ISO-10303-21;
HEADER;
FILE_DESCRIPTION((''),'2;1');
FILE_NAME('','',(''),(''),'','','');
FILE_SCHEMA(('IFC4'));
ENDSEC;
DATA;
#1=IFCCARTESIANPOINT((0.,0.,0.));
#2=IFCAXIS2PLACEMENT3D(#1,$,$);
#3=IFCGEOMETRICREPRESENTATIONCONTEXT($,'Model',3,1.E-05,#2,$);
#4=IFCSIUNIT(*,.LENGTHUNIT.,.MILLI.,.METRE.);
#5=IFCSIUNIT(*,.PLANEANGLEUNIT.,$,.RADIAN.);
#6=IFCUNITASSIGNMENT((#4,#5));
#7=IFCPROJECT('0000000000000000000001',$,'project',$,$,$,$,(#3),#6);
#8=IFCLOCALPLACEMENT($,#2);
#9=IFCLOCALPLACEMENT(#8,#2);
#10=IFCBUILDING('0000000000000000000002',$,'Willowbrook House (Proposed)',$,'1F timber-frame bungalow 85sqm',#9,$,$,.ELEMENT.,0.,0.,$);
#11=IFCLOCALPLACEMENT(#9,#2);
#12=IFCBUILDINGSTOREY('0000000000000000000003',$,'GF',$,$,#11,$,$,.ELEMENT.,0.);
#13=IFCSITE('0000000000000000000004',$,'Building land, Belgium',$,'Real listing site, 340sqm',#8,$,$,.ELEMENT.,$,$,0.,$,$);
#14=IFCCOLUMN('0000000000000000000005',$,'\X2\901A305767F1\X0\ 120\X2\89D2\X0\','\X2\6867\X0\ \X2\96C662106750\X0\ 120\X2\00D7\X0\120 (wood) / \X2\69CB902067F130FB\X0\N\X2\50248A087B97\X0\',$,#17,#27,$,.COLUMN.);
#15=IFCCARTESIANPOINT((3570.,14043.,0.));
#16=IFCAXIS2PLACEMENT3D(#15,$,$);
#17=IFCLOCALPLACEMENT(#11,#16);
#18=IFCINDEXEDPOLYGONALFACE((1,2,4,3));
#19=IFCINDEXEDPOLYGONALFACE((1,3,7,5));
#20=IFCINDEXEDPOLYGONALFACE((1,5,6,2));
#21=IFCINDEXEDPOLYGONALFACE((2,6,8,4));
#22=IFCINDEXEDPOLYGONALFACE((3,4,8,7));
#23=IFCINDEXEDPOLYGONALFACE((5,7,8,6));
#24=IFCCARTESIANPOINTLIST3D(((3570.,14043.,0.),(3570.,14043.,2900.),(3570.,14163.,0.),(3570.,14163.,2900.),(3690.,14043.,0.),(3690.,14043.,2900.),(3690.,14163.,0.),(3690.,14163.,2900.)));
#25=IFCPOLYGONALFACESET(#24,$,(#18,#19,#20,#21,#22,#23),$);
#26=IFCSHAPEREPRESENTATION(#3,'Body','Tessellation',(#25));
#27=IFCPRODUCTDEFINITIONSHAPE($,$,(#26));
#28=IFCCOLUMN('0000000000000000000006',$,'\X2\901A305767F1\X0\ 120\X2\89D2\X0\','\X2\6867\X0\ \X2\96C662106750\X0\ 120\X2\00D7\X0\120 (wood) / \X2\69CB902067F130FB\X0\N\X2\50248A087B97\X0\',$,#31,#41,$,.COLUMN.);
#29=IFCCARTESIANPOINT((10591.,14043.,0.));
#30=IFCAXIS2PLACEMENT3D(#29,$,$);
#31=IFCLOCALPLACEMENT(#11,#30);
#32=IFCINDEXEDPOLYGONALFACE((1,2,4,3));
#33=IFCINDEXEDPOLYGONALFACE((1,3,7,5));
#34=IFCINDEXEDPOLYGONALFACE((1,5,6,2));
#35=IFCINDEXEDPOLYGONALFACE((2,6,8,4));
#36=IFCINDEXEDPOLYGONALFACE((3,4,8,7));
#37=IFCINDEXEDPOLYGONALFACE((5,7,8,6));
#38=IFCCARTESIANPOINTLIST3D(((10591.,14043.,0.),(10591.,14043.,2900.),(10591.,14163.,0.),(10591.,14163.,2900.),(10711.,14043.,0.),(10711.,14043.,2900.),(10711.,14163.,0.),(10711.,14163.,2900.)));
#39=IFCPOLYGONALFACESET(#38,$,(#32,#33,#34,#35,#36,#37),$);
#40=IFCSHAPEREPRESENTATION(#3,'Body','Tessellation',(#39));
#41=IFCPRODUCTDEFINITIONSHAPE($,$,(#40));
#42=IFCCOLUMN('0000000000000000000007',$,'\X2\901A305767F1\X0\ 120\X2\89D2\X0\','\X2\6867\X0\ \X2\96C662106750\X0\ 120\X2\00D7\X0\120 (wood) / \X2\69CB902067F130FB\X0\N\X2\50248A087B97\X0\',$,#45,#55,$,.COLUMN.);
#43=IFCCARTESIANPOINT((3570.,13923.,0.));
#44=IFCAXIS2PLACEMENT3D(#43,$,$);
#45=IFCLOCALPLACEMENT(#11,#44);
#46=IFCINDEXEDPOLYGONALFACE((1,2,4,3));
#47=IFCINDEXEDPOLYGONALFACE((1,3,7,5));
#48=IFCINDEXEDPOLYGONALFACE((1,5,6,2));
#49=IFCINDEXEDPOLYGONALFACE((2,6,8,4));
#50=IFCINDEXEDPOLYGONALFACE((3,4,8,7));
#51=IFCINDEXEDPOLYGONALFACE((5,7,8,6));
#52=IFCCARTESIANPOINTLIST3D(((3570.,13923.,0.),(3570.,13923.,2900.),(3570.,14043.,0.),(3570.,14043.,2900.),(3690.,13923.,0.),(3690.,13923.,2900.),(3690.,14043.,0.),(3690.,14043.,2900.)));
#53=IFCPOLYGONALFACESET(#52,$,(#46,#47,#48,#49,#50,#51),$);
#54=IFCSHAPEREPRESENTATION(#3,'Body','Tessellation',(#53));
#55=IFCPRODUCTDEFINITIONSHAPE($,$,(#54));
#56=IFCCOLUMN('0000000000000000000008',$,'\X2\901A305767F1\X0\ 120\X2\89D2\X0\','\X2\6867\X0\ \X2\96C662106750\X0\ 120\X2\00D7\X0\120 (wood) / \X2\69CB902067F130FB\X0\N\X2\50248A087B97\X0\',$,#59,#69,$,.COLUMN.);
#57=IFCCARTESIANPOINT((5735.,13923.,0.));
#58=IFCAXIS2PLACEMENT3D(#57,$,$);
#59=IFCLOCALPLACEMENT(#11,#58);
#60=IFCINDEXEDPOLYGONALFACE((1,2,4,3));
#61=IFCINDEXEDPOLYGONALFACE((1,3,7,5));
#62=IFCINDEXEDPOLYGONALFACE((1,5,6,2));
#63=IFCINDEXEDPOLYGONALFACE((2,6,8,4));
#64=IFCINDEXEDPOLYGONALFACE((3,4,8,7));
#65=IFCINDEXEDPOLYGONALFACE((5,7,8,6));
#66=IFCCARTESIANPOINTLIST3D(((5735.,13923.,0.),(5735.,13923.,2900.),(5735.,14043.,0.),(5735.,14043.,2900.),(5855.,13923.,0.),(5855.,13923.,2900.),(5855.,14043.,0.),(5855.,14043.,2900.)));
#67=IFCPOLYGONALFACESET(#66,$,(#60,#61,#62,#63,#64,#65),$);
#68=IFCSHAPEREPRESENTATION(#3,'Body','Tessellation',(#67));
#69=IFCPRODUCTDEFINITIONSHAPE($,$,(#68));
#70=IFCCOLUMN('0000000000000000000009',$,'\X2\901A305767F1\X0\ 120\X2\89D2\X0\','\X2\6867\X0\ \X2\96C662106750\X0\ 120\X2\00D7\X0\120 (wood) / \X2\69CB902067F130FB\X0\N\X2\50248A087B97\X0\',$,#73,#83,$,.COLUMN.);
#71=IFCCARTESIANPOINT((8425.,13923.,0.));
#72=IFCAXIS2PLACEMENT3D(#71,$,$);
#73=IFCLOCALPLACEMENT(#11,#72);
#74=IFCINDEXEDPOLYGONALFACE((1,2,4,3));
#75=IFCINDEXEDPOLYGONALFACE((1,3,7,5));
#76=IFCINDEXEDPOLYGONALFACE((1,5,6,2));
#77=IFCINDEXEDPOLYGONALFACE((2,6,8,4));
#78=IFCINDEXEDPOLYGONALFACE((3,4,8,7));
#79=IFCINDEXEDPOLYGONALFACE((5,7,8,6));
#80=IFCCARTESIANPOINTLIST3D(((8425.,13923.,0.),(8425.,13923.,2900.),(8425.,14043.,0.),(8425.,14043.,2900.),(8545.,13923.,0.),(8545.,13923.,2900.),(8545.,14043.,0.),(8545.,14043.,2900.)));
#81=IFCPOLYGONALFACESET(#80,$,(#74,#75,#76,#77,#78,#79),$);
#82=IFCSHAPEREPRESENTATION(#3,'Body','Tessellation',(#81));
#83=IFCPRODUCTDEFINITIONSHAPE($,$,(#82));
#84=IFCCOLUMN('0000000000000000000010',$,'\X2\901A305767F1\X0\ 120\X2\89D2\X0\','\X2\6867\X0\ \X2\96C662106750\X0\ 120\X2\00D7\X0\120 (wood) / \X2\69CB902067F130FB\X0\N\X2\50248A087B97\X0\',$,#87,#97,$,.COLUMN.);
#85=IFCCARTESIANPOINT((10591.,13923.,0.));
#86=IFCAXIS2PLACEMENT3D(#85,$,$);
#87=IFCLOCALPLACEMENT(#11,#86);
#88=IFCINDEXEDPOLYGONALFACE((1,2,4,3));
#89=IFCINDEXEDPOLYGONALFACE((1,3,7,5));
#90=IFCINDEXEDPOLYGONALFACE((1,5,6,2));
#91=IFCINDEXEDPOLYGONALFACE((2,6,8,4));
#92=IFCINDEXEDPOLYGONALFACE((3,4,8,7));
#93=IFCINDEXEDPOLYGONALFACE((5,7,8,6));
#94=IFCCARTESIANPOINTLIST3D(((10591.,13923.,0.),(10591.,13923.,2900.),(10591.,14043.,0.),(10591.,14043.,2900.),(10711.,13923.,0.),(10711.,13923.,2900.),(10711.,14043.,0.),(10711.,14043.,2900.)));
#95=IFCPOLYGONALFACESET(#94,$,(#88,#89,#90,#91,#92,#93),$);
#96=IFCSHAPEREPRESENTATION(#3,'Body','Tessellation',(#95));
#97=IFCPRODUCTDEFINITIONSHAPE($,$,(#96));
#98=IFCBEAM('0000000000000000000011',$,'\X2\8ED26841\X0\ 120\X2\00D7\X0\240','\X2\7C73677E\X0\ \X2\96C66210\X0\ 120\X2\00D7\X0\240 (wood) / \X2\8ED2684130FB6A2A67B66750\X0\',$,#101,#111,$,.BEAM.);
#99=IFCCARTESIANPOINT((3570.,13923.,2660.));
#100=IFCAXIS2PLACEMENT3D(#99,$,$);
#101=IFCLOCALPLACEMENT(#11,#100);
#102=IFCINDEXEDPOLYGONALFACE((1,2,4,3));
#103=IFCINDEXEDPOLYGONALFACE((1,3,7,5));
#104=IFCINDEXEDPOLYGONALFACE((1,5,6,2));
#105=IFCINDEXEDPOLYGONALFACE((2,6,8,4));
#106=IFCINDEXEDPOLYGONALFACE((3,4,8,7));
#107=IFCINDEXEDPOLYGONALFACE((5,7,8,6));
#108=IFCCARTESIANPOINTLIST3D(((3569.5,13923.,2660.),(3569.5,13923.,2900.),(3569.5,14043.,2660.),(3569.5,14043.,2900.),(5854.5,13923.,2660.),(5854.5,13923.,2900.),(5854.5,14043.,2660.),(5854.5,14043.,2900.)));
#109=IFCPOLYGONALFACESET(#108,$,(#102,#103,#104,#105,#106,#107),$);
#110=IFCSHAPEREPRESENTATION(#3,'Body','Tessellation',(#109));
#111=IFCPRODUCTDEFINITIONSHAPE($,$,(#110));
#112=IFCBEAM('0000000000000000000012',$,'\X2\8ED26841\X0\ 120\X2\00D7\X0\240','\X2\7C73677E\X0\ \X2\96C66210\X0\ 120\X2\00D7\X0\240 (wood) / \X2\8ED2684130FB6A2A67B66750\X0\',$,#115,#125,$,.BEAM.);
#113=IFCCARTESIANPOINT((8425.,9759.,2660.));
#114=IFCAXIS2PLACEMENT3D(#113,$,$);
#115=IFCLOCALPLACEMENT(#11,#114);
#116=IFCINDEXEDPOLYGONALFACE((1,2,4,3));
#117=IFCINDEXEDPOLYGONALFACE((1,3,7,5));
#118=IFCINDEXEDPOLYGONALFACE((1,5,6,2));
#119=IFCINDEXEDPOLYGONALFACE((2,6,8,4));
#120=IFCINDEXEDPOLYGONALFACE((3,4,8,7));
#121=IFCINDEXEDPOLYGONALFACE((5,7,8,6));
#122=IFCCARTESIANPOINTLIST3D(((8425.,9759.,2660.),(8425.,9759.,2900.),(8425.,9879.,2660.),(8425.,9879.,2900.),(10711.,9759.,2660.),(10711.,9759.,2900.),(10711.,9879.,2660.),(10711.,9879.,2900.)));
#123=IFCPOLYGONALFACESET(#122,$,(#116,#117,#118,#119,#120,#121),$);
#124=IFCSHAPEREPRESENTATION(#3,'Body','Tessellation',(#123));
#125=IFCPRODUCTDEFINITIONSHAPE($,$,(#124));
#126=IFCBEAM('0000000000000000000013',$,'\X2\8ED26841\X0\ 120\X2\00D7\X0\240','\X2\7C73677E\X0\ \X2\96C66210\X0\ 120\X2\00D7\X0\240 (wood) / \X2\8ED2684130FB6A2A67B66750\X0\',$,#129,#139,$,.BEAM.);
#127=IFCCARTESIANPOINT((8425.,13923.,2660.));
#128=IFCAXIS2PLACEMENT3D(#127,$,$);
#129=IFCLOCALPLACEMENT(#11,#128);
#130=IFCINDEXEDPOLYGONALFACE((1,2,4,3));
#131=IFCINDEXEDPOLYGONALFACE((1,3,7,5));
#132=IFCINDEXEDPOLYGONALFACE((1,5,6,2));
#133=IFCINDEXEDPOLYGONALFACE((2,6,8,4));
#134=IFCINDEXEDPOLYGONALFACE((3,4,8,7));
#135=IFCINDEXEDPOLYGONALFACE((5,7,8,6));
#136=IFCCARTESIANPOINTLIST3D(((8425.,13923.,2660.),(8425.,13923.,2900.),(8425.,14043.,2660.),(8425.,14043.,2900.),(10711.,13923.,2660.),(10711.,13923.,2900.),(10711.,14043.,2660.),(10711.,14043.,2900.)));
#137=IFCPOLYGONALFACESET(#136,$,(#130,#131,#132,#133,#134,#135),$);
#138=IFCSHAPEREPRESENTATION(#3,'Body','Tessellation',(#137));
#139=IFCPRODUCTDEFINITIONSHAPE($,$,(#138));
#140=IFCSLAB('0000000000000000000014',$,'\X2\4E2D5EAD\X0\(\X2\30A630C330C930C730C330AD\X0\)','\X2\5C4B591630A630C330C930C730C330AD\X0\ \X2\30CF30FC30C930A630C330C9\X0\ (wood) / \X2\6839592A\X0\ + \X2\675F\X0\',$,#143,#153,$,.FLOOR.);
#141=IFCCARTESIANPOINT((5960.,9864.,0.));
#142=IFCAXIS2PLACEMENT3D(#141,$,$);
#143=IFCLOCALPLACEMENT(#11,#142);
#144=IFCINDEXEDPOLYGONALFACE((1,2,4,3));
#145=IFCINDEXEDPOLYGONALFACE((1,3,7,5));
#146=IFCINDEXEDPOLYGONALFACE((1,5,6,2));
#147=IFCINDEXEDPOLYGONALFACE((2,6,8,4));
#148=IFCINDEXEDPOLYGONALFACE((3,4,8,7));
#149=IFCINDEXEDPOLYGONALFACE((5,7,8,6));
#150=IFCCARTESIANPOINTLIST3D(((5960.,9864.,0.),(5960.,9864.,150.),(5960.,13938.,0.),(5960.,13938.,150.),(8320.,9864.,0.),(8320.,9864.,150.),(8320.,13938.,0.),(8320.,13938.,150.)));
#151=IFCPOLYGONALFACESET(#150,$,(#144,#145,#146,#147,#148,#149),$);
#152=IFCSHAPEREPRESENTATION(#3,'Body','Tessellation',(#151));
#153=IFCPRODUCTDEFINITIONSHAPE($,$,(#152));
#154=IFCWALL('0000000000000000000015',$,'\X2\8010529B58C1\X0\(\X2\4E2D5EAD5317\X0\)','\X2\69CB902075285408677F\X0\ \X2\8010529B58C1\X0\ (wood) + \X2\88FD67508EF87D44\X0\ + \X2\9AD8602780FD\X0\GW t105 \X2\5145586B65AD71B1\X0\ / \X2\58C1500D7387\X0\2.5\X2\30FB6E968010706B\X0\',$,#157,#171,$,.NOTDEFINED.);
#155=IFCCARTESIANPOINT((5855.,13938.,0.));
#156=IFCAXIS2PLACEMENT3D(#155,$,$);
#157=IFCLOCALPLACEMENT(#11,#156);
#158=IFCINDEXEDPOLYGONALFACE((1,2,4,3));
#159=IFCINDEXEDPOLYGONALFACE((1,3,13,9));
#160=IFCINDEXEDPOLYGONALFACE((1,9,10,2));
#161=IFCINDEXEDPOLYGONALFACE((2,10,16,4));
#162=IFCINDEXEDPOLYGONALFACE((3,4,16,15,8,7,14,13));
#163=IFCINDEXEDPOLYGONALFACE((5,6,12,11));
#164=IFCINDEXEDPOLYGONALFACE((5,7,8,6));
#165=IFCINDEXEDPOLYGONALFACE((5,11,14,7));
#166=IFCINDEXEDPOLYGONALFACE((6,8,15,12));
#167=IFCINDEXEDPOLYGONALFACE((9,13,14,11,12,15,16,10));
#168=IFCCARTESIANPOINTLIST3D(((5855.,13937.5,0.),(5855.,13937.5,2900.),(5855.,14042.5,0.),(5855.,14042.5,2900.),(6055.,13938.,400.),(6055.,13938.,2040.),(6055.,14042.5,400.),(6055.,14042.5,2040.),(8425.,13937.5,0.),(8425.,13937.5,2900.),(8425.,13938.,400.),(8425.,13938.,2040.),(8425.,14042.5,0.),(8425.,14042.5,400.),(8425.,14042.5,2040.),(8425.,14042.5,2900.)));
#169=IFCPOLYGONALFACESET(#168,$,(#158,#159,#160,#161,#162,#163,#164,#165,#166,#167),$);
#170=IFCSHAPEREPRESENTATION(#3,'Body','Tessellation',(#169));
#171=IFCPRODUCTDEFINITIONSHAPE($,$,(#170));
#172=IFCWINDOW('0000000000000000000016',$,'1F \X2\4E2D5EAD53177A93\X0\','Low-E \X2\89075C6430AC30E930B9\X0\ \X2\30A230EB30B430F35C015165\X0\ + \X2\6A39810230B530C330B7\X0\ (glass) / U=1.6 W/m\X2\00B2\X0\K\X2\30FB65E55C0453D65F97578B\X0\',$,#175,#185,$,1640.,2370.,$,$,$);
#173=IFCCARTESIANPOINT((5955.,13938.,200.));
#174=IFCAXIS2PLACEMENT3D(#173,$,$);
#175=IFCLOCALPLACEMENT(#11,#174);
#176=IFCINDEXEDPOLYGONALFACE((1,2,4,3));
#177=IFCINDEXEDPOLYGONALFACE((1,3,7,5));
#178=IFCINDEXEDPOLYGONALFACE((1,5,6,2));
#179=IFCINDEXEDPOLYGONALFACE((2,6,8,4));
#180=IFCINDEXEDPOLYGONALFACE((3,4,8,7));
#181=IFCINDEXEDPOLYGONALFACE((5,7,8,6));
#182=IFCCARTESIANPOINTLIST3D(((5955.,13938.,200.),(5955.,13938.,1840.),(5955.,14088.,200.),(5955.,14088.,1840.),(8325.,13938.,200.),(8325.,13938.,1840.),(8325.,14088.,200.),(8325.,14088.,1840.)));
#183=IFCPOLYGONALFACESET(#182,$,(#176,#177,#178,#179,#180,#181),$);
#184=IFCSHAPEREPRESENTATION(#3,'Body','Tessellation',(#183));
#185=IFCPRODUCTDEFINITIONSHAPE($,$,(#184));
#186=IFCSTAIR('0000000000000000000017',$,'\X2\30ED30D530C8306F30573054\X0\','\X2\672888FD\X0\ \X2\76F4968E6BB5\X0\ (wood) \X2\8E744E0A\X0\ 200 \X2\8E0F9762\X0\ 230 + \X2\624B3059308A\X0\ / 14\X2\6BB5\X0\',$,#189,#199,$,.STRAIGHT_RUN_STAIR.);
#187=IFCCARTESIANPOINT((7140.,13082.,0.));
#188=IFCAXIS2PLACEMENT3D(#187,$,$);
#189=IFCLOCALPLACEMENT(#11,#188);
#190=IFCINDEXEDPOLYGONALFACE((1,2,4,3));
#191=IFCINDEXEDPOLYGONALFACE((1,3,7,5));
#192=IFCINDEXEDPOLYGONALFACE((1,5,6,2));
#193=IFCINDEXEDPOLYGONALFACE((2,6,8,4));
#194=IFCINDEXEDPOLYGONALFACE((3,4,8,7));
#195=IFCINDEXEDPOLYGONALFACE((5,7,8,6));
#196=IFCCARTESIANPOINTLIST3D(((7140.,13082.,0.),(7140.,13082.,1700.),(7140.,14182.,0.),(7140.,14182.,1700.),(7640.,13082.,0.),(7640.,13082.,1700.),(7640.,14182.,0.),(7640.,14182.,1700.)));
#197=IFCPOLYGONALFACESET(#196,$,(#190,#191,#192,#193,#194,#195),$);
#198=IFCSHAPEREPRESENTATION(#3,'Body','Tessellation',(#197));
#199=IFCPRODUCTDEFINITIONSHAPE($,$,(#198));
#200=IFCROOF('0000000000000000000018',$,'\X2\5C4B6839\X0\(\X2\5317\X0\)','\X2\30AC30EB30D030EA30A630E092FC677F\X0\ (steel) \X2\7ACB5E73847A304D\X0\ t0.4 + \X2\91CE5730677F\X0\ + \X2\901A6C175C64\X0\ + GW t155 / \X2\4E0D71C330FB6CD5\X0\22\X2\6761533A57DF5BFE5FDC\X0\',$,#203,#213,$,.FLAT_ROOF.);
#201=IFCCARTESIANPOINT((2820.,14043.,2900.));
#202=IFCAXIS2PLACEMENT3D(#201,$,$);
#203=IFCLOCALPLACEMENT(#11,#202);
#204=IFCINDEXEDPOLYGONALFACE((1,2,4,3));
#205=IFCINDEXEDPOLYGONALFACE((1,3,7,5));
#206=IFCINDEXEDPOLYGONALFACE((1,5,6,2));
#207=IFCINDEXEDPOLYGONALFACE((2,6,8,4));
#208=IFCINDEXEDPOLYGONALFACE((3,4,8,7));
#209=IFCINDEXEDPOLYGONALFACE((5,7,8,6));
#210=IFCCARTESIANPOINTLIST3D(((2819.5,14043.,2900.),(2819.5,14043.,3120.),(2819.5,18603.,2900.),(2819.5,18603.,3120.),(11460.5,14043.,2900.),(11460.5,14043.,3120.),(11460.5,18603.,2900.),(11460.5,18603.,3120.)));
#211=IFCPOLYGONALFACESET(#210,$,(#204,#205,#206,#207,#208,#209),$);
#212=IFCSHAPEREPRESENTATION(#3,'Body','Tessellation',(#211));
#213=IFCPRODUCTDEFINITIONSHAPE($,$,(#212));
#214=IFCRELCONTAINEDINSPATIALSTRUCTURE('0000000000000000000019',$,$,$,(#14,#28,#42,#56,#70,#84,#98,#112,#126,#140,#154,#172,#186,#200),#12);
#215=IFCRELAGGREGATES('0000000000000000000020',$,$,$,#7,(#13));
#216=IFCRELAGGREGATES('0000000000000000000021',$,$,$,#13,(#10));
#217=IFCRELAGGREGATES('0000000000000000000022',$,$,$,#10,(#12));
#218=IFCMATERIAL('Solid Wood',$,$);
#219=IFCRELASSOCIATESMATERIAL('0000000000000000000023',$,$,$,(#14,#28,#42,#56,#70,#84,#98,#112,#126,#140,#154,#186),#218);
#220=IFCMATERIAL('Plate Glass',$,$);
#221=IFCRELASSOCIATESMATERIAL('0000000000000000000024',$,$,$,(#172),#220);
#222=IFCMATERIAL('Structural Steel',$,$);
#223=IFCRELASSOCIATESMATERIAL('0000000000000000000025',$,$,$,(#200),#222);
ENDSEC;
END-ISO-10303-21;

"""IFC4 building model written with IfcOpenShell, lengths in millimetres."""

from ifc_helpers import new_model, si_unit, frame, frame_2d, origin, place, context, project, spatial, rectangle, extrude, material, element, fill, save


model = new_model("IFC4")

# Units and contexts
model_context = context("Model", 3, precision=1e-05, world=origin())
ifc_project = project(units=[si_unit("LENGTHUNIT", "METRE", prefix="MILLI"), si_unit("PLANEANGLEUNIT", "RADIAN")], contexts=[model_context])

# Site, building, storey
site_placement = place(None, origin())
site = spatial("IfcSite", under=ifc_project, at=site_placement, Name="Building land, Belgium", ObjectType="Real listing site, 340sqm", CompositionType="ELEMENT", RefElevation=0.0)
building_placement = place(site_placement, origin())
building = spatial("IfcBuilding", under=site, at=building_placement, Name="Willowbrook House (Proposed)", ObjectType="1F timber-frame bungalow 85sqm", CompositionType="ELEMENT", ElevationOfRefHeight=0.0, ElevationOfTerrain=0.0)
storey_placement = place(building_placement, origin())
storey = spatial("IfcBuildingStorey", under=building, at=storey_placement, Name="GF", CompositionType="ELEMENT", Elevation=0.0)

# Columns
ifc_material_1 = material(Name="Solid Wood")
column_1_placement = place(storey_placement, frame((3570.0, 14043.0, 0.0)))
element("IfcColumn", 1, at=column_1_placement, inside=storey, material=ifc_material_1, Name="通し柱 120角", Description="桧 集成材 120×120 (wood) / 構造柱・N値計算", PredefinedType="COLUMN", context=model_context, shape_type="SweptSolid", body=[
    extrude(rectangle(XDim=120.0, YDim=120.0, at=frame_2d((60.0, 60.0))), frame((3570.0, 14043.0, 0.0)), (0.0, 0.0, 1.0), 2900.0),
])
column_2_placement = place(storey_placement, frame((10591.0, 14043.0, 0.0)))
element("IfcColumn", 2, at=column_2_placement, inside=storey, material=ifc_material_1, Name="通し柱 120角", Description="桧 集成材 120×120 (wood) / 構造柱・N値計算", PredefinedType="COLUMN", context=model_context, shape_type="SweptSolid", body=[
    extrude(rectangle(XDim=120.0, YDim=120.0, at=frame_2d((60.0, 60.0))), frame((10591.0, 14043.0, 0.0)), (0.0, 0.0, 1.0), 2900.0),
])
column_3_placement = place(storey_placement, frame((3570.0, 13923.0, 0.0)))
element("IfcColumn", 3, at=column_3_placement, inside=storey, material=ifc_material_1, Name="通し柱 120角", Description="桧 集成材 120×120 (wood) / 構造柱・N値計算", PredefinedType="COLUMN", context=model_context, shape_type="SweptSolid", body=[
    extrude(rectangle(XDim=120.0, YDim=120.0, at=frame_2d((60.0, 60.0))), frame((3570.0, 13923.0, 0.0)), (0.0, 0.0, 1.0), 2900.0),
])
column_4_placement = place(storey_placement, frame((5735.0, 13923.0, 0.0)))
element("IfcColumn", 4, at=column_4_placement, inside=storey, material=ifc_material_1, Name="通し柱 120角", Description="桧 集成材 120×120 (wood) / 構造柱・N値計算", PredefinedType="COLUMN", context=model_context, shape_type="SweptSolid", body=[
    extrude(rectangle(XDim=120.0, YDim=120.0, at=frame_2d((60.0, 60.0))), frame((5735.0, 13923.0, 0.0)), (0.0, 0.0, 1.0), 2900.0),
])
column_5_placement = place(storey_placement, frame((8425.0, 13923.0, 0.0)))
element("IfcColumn", 5, at=column_5_placement, inside=storey, material=ifc_material_1, Name="通し柱 120角", Description="桧 集成材 120×120 (wood) / 構造柱・N値計算", PredefinedType="COLUMN", context=model_context, shape_type="SweptSolid", body=[
    extrude(rectangle(XDim=120.0, YDim=120.0, at=frame_2d((60.0, 60.0))), frame((8425.0, 13923.0, 0.0)), (0.0, 0.0, 1.0), 2900.0),
])
column_6_placement = place(storey_placement, frame((10591.0, 13923.0, 0.0)))
element("IfcColumn", 6, at=column_6_placement, inside=storey, material=ifc_material_1, Name="通し柱 120角", Description="桧 集成材 120×120 (wood) / 構造柱・N値計算", PredefinedType="COLUMN", context=model_context, shape_type="SweptSolid", body=[
    extrude(rectangle(XDim=120.0, YDim=120.0, at=frame_2d((60.0, 60.0))), frame((10591.0, 13923.0, 0.0)), (0.0, 0.0, 1.0), 2900.0),
])

# Beams
beam_1_placement = place(storey_placement, frame((3570.0, 13923.0, 2660.0)))
element("IfcBeam", 7, at=beam_1_placement, inside=storey, material=ifc_material_1, Name="軒桁 120×240", Description="米松 集成 120×240 (wood) / 軒桁・横架材", PredefinedType="BEAM", context=model_context, shape_type="SweptSolid", body=[
    extrude(rectangle(XDim=2285.0, YDim=120.0, at=frame_2d((1142.0, 60.0))), frame((3570.0, 13923.0, 2660.0)), (0.0, 0.0, 1.0), 240.0),
])
beam_2_placement = place(storey_placement, frame((8425.0, 9759.0, 2660.0)))
element("IfcBeam", 8, at=beam_2_placement, inside=storey, material=ifc_material_1, Name="軒桁 120×240", Description="米松 集成 120×240 (wood) / 軒桁・横架材", PredefinedType="BEAM", context=model_context, shape_type="SweptSolid", body=[
    extrude(rectangle(XDim=2286.0, YDim=120.0, at=frame_2d((1143.0, 60.0))), frame((8425.0, 9759.0, 2660.0)), (0.0, 0.0, 1.0), 240.0),
])
beam_3_placement = place(storey_placement, frame((8425.0, 13923.0, 2660.0)))
element("IfcBeam", 9, at=beam_3_placement, inside=storey, material=ifc_material_1, Name="軒桁 120×240", Description="米松 集成 120×240 (wood) / 軒桁・横架材", PredefinedType="BEAM", context=model_context, shape_type="SweptSolid", body=[
    extrude(rectangle(XDim=2286.0, YDim=120.0, at=frame_2d((1143.0, 60.0))), frame((8425.0, 13923.0, 2660.0)), (0.0, 0.0, 1.0), 240.0),
])

# Slab
slab_1_placement = place(storey_placement, frame((5960.0, 9864.0, 0.0)))
element("IfcSlab", 10, at=slab_1_placement, inside=storey, material=ifc_material_1, Name="中庭(ウッドデッキ)", Description="屋外ウッドデッキ ハードウッド (wood) / 根太 + 束", PredefinedType="FLOOR", context=model_context, shape_type="SweptSolid", body=[
    extrude(rectangle(XDim=2360.0, YDim=4074.0, at=frame_2d((1180.0, 2037.0))), frame((5960.0, 9864.0, 0.0)), (0.0, 0.0, 1.0), 150.0),
])

# Wall, opening, window
wall_placement = place(storey_placement, frame((5855.0, 13938.0, 0.0)))
wall = element("IfcWall", 11, at=wall_placement, inside=storey, material=ifc_material_1, Name="耐力壁(中庭北)", Description="構造用合板 耐力壁 (wood) + 製材軸組 + 高性能GW t105 充填断熱 / 壁倍率2.5・準耐火", PredefinedType="NOTDEFINED", context=model_context, shape_type="SweptSolid", body=[
    extrude(rectangle(XDim=2570.0, YDim=105.0, at=frame_2d((1285.0, 52.0))), frame((5855.0, 13938.0, 0.0)), (0.0, 0.0, 1.0), 2900.0),
])
opening_placement = place(storey_placement, frame((5955.0, 13938.0, 200.0)))
opening = element("IfcOpeningElement", 12, at=opening_placement, cuts=wall, PredefinedType="NOTDEFINED", context=model_context, shape_type="SweptSolid", body=[
    extrude(rectangle(XDim=2370.0, YDim=150.0, at=frame_2d((1185.0, 75.0))), frame((5955.0, 13938.0, 200.0)), (0.0, 0.0, 1.0), 1640.0),
])
ifc_material_2 = material(Name="Plate Glass")
window_placement = place(storey_placement, frame((5955.0, 13938.0, 200.0)))
window = element("IfcWindow", 13, at=window_placement, inside=storey, material=ifc_material_2, Name="1F 中庭北窓", Description="Low-E 複層ガラス アルゴン封入 + 樹脂サッシ (glass) / U=1.6 W/m²K・日射取得型", OverallHeight=1640.0, OverallWidth=2370.0, context=model_context, shape_type="SweptSolid", body=[
    extrude(rectangle(XDim=2370.0, YDim=150.0, at=frame_2d((1185.0, 75.0))), frame((5955.0, 13938.0, 200.0)), (0.0, 0.0, 1.0), 1640.0),
])
fill(opening, window)

# Stair
stair_placement = place(storey_placement, frame((7140.0, 13082.0, 0.0)))
element("IfcStair", 14, at=stair_placement, inside=storey, material=ifc_material_1, Name="ロフトはしご", Description="木製 直階段 (wood) 蹴上 200 踏面 230 + 手すり / 14段", PredefinedType="STRAIGHT_RUN_STAIR", context=model_context, shape_type="SweptSolid", body=[
    extrude(rectangle(XDim=500.0, YDim=1100.0, at=frame_2d((250.0, 550.0))), frame((7140.0, 13082.0, 0.0)), (0.0, 0.0, 1.0), 1700.0),
])

# Roof
ifc_material_3 = material(Name="Structural Steel")
roof_placement = place(storey_placement, frame((2820.0, 14043.0, 2900.0)))
element("IfcRoof", 15, at=roof_placement, inside=storey, material=ifc_material_3, Name="屋根(北)", Description="ガルバリウム鋼板 (steel) 立平葺き t0.4 + 野地板 + 通気層 + GW t155 / 不燃・法22条区域対応", PredefinedType="FLAT_ROOF", context=model_context, shape_type="SweptSolid", body=[
    extrude(rectangle(XDim=8641.0, YDim=4560.0, at=frame_2d((4320.0, 2280.0))), frame((2820.0, 14043.0, 2900.0)), (0.0, 0.0, 1.0), 220.0),
])

save(model, "model.ifc")
